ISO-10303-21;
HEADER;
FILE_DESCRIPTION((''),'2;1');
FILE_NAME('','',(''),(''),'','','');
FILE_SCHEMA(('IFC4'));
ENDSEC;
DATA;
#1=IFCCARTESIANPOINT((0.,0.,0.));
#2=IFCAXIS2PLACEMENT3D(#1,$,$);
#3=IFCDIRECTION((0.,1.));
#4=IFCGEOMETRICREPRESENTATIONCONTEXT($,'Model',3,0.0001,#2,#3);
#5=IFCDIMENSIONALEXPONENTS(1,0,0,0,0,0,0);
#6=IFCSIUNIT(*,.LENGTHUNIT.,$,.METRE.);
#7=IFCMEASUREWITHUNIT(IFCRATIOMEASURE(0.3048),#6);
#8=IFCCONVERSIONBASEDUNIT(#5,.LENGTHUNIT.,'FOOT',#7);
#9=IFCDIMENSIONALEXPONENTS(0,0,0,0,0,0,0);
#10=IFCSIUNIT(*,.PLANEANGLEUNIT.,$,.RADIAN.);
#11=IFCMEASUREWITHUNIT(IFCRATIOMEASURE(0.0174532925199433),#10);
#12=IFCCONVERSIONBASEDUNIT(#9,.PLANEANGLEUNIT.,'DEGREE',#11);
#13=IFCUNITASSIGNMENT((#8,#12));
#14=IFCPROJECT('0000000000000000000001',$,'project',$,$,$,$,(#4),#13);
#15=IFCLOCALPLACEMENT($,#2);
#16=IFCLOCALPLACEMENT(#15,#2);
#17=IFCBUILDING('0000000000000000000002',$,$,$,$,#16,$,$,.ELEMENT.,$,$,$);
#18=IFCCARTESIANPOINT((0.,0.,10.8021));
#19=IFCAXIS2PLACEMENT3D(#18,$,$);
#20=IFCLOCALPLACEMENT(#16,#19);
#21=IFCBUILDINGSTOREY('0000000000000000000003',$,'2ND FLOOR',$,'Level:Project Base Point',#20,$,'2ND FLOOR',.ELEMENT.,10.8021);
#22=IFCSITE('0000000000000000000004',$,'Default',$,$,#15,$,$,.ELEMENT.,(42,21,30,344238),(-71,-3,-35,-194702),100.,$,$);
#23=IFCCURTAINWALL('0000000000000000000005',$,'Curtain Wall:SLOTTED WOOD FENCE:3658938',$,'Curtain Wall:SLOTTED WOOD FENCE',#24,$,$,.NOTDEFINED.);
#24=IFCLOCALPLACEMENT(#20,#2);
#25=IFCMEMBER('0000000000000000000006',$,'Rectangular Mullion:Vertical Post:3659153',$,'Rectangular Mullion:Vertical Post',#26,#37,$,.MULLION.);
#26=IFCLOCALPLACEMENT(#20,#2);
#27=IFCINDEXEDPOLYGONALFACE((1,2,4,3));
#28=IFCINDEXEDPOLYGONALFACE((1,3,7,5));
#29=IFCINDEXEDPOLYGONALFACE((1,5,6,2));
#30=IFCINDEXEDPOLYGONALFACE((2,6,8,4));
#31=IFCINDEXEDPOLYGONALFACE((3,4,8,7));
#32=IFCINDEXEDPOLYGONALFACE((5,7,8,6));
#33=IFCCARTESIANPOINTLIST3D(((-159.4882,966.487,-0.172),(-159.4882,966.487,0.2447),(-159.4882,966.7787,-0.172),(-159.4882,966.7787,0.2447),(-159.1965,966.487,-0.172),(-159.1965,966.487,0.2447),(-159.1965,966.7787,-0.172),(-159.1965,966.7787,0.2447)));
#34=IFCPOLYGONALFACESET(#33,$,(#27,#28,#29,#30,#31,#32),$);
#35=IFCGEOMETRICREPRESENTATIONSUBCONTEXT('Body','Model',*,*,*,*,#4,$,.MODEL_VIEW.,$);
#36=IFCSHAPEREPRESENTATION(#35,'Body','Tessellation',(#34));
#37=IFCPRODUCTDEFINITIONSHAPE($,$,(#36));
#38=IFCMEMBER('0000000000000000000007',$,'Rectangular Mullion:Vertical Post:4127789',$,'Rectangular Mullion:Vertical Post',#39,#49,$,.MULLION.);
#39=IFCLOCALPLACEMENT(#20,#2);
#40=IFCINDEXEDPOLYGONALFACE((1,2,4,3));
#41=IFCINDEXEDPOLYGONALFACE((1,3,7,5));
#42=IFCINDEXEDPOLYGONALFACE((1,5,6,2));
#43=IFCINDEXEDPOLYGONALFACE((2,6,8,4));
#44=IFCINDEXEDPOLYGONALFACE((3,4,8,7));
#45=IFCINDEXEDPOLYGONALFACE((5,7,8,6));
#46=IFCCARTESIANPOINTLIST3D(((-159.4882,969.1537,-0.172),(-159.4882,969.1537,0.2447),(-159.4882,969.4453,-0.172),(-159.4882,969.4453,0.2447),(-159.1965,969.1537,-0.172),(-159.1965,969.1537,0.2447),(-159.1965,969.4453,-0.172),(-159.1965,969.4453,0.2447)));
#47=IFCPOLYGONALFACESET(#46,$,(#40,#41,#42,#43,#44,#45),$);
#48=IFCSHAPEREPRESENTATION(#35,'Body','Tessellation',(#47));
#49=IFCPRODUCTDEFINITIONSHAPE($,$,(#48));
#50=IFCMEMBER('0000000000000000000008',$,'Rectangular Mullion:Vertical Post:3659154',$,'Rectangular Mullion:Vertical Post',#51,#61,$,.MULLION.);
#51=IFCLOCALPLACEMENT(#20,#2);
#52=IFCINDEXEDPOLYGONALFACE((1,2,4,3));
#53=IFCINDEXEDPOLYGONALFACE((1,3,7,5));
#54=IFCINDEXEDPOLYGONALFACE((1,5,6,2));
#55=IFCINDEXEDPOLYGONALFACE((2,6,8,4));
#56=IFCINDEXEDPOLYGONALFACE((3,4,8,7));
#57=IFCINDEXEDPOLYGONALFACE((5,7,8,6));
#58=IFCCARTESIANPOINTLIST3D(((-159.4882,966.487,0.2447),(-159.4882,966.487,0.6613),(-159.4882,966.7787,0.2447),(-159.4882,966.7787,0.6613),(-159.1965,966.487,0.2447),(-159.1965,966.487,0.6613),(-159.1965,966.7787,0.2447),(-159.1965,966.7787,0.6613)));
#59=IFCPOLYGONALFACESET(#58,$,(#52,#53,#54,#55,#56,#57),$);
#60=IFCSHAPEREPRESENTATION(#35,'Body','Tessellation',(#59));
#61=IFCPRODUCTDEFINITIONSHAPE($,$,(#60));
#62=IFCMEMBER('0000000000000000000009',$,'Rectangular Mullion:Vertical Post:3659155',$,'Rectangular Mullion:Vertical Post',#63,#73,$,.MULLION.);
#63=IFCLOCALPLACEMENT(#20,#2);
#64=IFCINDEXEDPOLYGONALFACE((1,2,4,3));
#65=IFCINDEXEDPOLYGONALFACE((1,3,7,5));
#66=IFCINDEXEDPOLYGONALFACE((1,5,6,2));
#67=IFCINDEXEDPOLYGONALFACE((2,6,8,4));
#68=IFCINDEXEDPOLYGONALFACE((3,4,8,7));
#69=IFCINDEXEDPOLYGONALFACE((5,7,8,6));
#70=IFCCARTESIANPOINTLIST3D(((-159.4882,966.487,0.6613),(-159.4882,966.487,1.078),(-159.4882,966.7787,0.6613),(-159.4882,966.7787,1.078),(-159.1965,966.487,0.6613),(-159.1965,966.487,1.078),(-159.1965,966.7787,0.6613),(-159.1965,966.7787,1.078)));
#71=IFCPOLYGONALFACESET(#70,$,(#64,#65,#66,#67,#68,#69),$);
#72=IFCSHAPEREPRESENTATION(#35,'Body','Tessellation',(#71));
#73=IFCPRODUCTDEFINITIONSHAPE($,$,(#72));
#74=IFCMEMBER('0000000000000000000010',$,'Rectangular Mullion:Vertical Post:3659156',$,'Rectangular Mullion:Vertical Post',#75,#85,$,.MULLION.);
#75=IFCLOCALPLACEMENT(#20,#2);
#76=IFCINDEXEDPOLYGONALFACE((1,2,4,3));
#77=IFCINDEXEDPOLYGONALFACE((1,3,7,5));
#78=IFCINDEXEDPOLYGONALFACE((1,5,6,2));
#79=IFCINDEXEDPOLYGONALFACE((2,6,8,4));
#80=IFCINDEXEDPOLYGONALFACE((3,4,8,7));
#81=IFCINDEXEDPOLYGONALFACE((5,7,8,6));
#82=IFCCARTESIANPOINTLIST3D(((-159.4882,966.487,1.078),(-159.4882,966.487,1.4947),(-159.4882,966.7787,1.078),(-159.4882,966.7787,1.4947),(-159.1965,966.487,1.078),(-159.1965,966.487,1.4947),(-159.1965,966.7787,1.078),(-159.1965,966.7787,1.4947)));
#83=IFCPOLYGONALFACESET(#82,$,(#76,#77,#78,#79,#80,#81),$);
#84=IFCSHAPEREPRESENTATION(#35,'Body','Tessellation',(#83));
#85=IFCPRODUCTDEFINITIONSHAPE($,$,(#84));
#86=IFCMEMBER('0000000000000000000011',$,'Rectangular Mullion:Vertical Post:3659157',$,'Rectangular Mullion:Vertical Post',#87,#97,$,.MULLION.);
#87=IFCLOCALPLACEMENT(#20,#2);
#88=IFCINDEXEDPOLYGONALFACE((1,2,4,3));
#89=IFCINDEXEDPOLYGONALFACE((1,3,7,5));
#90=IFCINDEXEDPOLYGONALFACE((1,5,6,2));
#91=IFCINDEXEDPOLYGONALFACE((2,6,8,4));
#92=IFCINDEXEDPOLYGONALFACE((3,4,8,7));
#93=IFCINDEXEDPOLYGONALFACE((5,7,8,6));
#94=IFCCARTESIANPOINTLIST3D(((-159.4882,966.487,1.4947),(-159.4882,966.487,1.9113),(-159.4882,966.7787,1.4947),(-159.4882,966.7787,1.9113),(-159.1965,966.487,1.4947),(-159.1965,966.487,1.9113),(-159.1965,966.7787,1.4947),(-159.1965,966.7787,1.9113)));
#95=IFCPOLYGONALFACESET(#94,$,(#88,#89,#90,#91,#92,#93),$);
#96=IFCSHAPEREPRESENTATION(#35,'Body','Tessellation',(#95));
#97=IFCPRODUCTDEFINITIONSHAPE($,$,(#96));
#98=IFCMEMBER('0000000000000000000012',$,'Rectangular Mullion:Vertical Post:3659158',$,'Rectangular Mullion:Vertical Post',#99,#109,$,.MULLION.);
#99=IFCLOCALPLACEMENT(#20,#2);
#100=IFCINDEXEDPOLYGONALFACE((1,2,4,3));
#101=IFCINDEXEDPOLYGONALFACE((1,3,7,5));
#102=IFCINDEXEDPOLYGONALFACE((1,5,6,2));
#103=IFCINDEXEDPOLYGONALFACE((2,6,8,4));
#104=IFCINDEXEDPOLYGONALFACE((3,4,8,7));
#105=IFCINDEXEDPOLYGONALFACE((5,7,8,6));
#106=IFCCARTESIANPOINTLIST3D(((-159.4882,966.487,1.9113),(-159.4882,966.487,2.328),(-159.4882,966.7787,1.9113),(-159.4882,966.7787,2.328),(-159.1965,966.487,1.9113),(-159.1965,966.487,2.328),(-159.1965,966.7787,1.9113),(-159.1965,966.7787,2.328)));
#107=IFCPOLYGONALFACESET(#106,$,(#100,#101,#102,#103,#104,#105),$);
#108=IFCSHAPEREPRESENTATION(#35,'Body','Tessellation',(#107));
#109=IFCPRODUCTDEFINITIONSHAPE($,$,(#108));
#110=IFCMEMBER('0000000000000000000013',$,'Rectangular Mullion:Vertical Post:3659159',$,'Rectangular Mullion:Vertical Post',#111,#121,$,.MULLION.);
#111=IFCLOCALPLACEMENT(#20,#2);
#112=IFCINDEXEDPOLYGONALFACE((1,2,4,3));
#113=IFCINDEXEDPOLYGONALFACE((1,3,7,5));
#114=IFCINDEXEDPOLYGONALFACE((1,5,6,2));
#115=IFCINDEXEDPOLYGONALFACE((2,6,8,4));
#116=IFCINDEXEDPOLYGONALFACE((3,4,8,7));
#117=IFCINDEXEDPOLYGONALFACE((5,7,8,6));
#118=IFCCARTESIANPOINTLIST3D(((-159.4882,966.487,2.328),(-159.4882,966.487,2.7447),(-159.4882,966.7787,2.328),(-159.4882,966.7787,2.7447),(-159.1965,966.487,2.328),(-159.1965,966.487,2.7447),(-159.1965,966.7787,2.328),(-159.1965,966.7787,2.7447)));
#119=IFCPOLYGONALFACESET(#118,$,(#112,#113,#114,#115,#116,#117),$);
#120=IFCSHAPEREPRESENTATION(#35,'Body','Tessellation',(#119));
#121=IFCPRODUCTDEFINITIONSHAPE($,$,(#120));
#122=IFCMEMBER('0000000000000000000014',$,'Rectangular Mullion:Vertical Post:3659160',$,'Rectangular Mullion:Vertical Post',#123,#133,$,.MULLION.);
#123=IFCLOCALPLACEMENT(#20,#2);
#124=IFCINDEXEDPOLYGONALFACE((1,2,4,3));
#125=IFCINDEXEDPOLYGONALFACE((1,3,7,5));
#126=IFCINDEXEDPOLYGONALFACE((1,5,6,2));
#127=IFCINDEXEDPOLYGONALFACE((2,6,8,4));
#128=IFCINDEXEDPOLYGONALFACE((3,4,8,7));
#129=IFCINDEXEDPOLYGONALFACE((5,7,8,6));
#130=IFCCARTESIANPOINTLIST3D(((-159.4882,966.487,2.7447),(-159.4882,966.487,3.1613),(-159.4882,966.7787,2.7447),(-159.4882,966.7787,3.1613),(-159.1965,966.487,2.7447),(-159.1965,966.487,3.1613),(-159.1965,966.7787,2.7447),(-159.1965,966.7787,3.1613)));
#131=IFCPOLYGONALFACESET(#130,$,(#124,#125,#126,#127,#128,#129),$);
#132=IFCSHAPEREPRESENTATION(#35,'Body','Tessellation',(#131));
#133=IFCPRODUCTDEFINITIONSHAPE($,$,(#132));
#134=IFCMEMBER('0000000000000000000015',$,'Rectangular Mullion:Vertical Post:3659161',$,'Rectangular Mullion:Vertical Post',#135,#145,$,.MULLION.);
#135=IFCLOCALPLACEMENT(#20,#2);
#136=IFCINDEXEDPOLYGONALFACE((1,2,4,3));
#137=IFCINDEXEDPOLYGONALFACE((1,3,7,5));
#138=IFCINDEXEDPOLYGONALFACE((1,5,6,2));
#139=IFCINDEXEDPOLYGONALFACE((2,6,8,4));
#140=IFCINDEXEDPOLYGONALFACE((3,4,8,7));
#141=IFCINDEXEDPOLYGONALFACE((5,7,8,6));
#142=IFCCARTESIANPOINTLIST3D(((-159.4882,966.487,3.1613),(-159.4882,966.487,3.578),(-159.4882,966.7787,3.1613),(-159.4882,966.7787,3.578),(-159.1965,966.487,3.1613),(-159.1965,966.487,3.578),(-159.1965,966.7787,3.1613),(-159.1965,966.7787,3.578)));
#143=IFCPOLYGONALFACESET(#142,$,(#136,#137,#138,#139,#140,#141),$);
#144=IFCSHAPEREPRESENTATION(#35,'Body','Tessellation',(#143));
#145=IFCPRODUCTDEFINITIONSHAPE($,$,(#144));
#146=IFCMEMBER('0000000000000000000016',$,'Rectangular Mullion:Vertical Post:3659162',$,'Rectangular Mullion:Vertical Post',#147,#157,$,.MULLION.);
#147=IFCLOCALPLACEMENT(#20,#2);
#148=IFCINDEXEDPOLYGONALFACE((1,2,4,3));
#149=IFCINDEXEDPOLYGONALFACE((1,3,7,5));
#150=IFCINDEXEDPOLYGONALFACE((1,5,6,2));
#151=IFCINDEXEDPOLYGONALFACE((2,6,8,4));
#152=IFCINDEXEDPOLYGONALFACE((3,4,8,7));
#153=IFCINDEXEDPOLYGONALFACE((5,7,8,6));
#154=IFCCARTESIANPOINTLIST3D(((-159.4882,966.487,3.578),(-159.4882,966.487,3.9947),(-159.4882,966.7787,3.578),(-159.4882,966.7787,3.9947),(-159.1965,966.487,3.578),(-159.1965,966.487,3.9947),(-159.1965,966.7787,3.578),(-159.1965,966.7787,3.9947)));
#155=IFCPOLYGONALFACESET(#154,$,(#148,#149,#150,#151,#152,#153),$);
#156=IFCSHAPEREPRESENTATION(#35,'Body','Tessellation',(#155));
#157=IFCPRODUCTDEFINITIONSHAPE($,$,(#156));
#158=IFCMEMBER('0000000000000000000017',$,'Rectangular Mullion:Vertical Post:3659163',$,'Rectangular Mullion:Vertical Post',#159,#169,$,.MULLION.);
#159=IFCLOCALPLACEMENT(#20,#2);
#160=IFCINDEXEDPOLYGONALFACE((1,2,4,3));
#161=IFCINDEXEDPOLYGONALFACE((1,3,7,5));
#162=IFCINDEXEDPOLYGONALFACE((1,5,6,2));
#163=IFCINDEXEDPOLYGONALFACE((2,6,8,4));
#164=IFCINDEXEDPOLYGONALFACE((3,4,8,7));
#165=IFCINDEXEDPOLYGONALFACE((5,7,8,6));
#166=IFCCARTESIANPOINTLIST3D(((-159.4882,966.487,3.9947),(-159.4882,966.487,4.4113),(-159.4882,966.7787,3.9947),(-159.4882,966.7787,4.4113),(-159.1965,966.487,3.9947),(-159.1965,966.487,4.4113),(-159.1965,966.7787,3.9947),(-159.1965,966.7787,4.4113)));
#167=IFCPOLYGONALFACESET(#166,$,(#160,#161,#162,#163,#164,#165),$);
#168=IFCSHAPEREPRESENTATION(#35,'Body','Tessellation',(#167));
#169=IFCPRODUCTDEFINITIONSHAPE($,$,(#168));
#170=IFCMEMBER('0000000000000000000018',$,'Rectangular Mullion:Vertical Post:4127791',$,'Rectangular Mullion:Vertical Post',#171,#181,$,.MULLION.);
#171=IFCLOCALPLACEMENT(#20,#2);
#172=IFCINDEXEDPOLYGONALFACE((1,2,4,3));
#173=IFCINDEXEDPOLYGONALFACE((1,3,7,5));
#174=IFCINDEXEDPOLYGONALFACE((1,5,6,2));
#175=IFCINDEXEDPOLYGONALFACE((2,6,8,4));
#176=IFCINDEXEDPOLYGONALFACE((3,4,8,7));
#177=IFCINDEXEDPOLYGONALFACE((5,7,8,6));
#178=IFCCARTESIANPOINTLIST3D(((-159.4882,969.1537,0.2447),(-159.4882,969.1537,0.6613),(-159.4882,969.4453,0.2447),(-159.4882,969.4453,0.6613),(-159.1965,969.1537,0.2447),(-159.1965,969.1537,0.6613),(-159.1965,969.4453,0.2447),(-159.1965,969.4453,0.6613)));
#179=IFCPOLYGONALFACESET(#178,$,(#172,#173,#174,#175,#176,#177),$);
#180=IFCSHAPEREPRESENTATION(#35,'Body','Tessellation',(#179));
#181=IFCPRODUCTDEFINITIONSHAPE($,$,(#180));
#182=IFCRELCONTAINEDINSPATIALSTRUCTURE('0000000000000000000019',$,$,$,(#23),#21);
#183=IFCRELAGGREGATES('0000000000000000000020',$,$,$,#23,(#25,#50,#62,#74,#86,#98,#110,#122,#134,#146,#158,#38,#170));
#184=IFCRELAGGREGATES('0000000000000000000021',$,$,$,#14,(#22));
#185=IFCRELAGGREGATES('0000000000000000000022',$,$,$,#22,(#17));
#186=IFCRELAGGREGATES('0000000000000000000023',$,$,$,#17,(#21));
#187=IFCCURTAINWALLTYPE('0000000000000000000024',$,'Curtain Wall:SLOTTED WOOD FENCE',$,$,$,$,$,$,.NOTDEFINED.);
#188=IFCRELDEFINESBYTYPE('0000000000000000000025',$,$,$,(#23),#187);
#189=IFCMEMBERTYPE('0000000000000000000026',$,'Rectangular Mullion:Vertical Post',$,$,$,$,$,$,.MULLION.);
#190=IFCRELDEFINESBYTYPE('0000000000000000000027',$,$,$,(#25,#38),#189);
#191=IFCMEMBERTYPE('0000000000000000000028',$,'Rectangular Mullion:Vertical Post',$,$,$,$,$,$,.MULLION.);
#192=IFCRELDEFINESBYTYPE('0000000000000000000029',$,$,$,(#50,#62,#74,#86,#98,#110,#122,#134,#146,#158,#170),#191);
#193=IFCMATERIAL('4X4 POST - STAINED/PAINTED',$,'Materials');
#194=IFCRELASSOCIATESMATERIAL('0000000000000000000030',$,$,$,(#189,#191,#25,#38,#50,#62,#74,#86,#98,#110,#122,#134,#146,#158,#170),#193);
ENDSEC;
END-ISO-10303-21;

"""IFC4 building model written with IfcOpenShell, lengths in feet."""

from ifc_helpers import new_model, entity, si_unit, converted_unit, direction, frame, origin, origin_2d_with_axis, place, context, subcontext, project, spatial, rectangle, extrude, source, transform, mapped, material, material_profile, profile_set, profile_usage, type_object, type_shapes, element, aggregate, save


model = new_model("IFC4")

# Units and contexts
model_context = context("Model", 3, precision=0.0001, world=origin(), true_north=direction((0.0, 1.0)))
body_context = subcontext(model_context, "Body", "Model", "MODEL_VIEW")
ifc_project = project(units=[converted_unit("LENGTHUNIT", "FOOT", entity("IfcRatioMeasure", 0.3048), si_unit("LENGTHUNIT", "METRE"), dimensions=[1, 0, 0, 0, 0, 0, 0]), converted_unit("PLANEANGLEUNIT", "DEGREE", entity("IfcRatioMeasure", 0.0174532925199433), si_unit("PLANEANGLEUNIT", "RADIAN"), dimensions=[0, 0, 0, 0, 0, 0, 0])], contexts=[model_context])

# Site, building, storey
site_placement = place(None, origin())
site = spatial("IfcSite", under=ifc_project, at=site_placement, Name="Default", CompositionType="ELEMENT", RefLatitude=(42, 21, 30, 344238), RefLongitude=(-71, -3, -35, -194702), RefElevation=100.0)
building_placement = place(site_placement, origin())
building = spatial("IfcBuilding", under=site, at=building_placement, CompositionType="ELEMENT")
storey_placement = place(building_placement, frame((0.0, 0.0, 10.8021)))
storey = spatial("IfcBuildingStorey", under=building, at=storey_placement, Name="2ND FLOOR", ObjectType="Level:Project Base Point", LongName="2ND FLOOR", CompositionType="ELEMENT", Elevation=10.8021)

# Curtain wall, members
curtain_wall_type = type_object("IfcCurtainWallType", Name="Curtain Wall:SLOTTED WOOD FENCE", PredefinedType="NOTDEFINED")
curtain_wall_placement = place(storey_placement, frame((0.0, 0.0, -10.8021)))
curtain_wall = element("IfcCurtainWall", 1, at=curtain_wall_placement, inside=storey, type_object=curtain_wall_type, Name="Curtain Wall:SLOTTED WOOD FENCE:3658938", ObjectType="Curtain Wall:SLOTTED WOOD FENCE", PredefinedType="NOTDEFINED")
ifc_material_1 = material(Name="4X4 POST - STAINED/PAINTED", Category="Materials")
ifc_material_profile = material_profile(ifc_material_1, rectangle(XDim=0.2917, YDim=0.2917, at=origin_2d_with_axis()), Name="Vertical Post")
ifc_profile_set = profile_set([ifc_material_profile], Name="Vertical Post")
ifc_profile_usage_1 = profile_usage(ifc_profile_set)
member_type_1 = type_object("IfcMemberType", Name="Rectangular Mullion:Vertical Post", PredefinedType="MULLION", material=ifc_profile_set)
shared_shape_1 = source(origin(), body_context, "Body", "SweptSolid", [
    extrude(rectangle(XDim=0.2917, YDim=0.2917, at=origin_2d_with_axis()), frame((0.0, -0.2083, -0.4167), z_axis=(0.0, 0.0, 1.0), x_axis=(0.0, -1.0, 0.0)), (0.0, 0.0, 1.0), 0.4167),
])
type_shapes(member_type_1, [shared_shape_1])
member_1_placement = place(storey_placement, frame((-159.5507, 966.6328, -0.172), z_axis=(0.0, 0.0, -1.0), x_axis=(0.0, -1.0, 0.0)))
member_1 = element("IfcMember", 2, at=member_1_placement, type_object=member_type_1, material=ifc_profile_usage_1, Name="Rectangular Mullion:Vertical Post:3659153", ObjectType="Rectangular Mullion:Vertical Post", PredefinedType="MULLION", context=body_context, shape_type="MappedRepresentation", body=[
    mapped(shared_shape_1, transform((0.0, 0.0, 0.0), scale=1.0)),
])
ifc_profile_usage_2 = profile_usage(ifc_profile_set)
member_2_placement = place(storey_placement, frame((-159.5507, 969.2995, -0.172), z_axis=(0.0, 0.0, -1.0), x_axis=(0.0, -1.0, 0.0)))
member_2 = element("IfcMember", 3, at=member_2_placement, type_object=member_type_1, material=ifc_profile_usage_2, Name="Rectangular Mullion:Vertical Post:4127789", ObjectType="Rectangular Mullion:Vertical Post", PredefinedType="MULLION", context=body_context, shape_type="MappedRepresentation", body=[
    mapped(shared_shape_1, transform((0.0, 0.0, 0.0), scale=1.0)),
])
ifc_profile_usage_3 = profile_usage(ifc_profile_set)
member_type_2 = type_object("IfcMemberType", Name="Rectangular Mullion:Vertical Post", PredefinedType="MULLION", material=ifc_profile_set)
shared_shape_2 = source(origin(), body_context, "Body", "SweptSolid", [
    extrude(rectangle(XDim=0.2917, YDim=0.2917, at=origin_2d_with_axis()), frame((0.0, -0.2083, -0.4167), z_axis=(0.0, 0.0, 1.0), x_axis=(0.0, -1.0, 0.0)), (0.0, 0.0, 1.0), 0.4167),
])
type_shapes(member_type_2, [shared_shape_2])
member_3_placement = place(storey_placement, frame((-159.5507, 966.6328, 0.2447), z_axis=(0.0, 0.0, -1.0), x_axis=(0.0, -1.0, 0.0)))
member_3 = element("IfcMember", 4, at=member_3_placement, type_object=member_type_2, material=ifc_profile_usage_3, Name="Rectangular Mullion:Vertical Post:3659154", ObjectType="Rectangular Mullion:Vertical Post", PredefinedType="MULLION", context=body_context, shape_type="MappedRepresentation", body=[
    mapped(shared_shape_2, transform((0.0, 0.0, 0.0), scale=1.0)),
])
ifc_profile_usage_4 = profile_usage(ifc_profile_set)
member_4_placement = place(storey_placement, frame((-159.5507, 966.6328, 0.6613), z_axis=(0.0, 0.0, -1.0), x_axis=(0.0, -1.0, 0.0)))
member_4 = element("IfcMember", 5, at=member_4_placement, type_object=member_type_2, material=ifc_profile_usage_4, Name="Rectangular Mullion:Vertical Post:3659155", ObjectType="Rectangular Mullion:Vertical Post", PredefinedType="MULLION", context=body_context, shape_type="MappedRepresentation", body=[
    mapped(shared_shape_2, transform((0.0, 0.0, 0.0), scale=1.0)),
])
ifc_profile_usage_5 = profile_usage(ifc_profile_set)
member_5_placement = place(storey_placement, frame((-159.5507, 966.6328, 1.078), z_axis=(0.0, 0.0, -1.0), x_axis=(0.0, -1.0, 0.0)))
member_5 = element("IfcMember", 6, at=member_5_placement, type_object=member_type_2, material=ifc_profile_usage_5, Name="Rectangular Mullion:Vertical Post:3659156", ObjectType="Rectangular Mullion:Vertical Post", PredefinedType="MULLION", context=body_context, shape_type="MappedRepresentation", body=[
    mapped(shared_shape_2, transform((0.0, 0.0, 0.0), scale=1.0)),
])
ifc_profile_usage_6 = profile_usage(ifc_profile_set)
member_6_placement = place(storey_placement, frame((-159.5507, 966.6328, 1.4947), z_axis=(0.0, 0.0, -1.0), x_axis=(0.0, -1.0, 0.0)))
member_6 = element("IfcMember", 7, at=member_6_placement, type_object=member_type_2, material=ifc_profile_usage_6, Name="Rectangular Mullion:Vertical Post:3659157", ObjectType="Rectangular Mullion:Vertical Post", PredefinedType="MULLION", context=body_context, shape_type="MappedRepresentation", body=[
    mapped(shared_shape_2, transform((0.0, 0.0, 0.0), scale=1.0)),
])
ifc_profile_usage_7 = profile_usage(ifc_profile_set)
member_7_placement = place(storey_placement, frame((-159.5507, 966.6328, 1.9113), z_axis=(0.0, 0.0, -1.0), x_axis=(0.0, -1.0, 0.0)))
member_7 = element("IfcMember", 8, at=member_7_placement, type_object=member_type_2, material=ifc_profile_usage_7, Name="Rectangular Mullion:Vertical Post:3659158", ObjectType="Rectangular Mullion:Vertical Post", PredefinedType="MULLION", context=body_context, shape_type="MappedRepresentation", body=[
    mapped(shared_shape_2, transform((0.0, 0.0, 0.0), scale=1.0)),
])
ifc_profile_usage_8 = profile_usage(ifc_profile_set)
member_8_placement = place(storey_placement, frame((-159.5507, 966.6328, 2.328), z_axis=(0.0, 0.0, -1.0), x_axis=(0.0, -1.0, 0.0)))
member_8 = element("IfcMember", 9, at=member_8_placement, type_object=member_type_2, material=ifc_profile_usage_8, Name="Rectangular Mullion:Vertical Post:3659159", ObjectType="Rectangular Mullion:Vertical Post", PredefinedType="MULLION", context=body_context, shape_type="MappedRepresentation", body=[
    mapped(shared_shape_2, transform((0.0, 0.0, 0.0), scale=1.0)),
])
ifc_profile_usage_9 = profile_usage(ifc_profile_set)
member_9_placement = place(storey_placement, frame((-159.5507, 966.6328, 2.7447), z_axis=(0.0, 0.0, -1.0), x_axis=(0.0, -1.0, 0.0)))
member_9 = element("IfcMember", 10, at=member_9_placement, type_object=member_type_2, material=ifc_profile_usage_9, Name="Rectangular Mullion:Vertical Post:3659160", ObjectType="Rectangular Mullion:Vertical Post", PredefinedType="MULLION", context=body_context, shape_type="MappedRepresentation", body=[
    mapped(shared_shape_2, transform((0.0, 0.0, 0.0), scale=1.0)),
])
ifc_profile_usage_10 = profile_usage(ifc_profile_set)
member_10_placement = place(storey_placement, frame((-159.5507, 966.6328, 3.1613), z_axis=(0.0, 0.0, -1.0), x_axis=(0.0, -1.0, 0.0)))
member_10 = element("IfcMember", 11, at=member_10_placement, type_object=member_type_2, material=ifc_profile_usage_10, Name="Rectangular Mullion:Vertical Post:3659161", ObjectType="Rectangular Mullion:Vertical Post", PredefinedType="MULLION", context=body_context, shape_type="MappedRepresentation", body=[
    mapped(shared_shape_2, transform((0.0, 0.0, 0.0), scale=1.0)),
])
ifc_profile_usage_11 = profile_usage(ifc_profile_set)
member_11_placement = place(storey_placement, frame((-159.5507, 966.6328, 3.578), z_axis=(0.0, 0.0, -1.0), x_axis=(0.0, -1.0, 0.0)))
member_11 = element("IfcMember", 12, at=member_11_placement, type_object=member_type_2, material=ifc_profile_usage_11, Name="Rectangular Mullion:Vertical Post:3659162", ObjectType="Rectangular Mullion:Vertical Post", PredefinedType="MULLION", context=body_context, shape_type="MappedRepresentation", body=[
    mapped(shared_shape_2, transform((0.0, 0.0, 0.0), scale=1.0)),
])
ifc_profile_usage_12 = profile_usage(ifc_profile_set)
member_12_placement = place(storey_placement, frame((-159.5507, 966.6328, 3.9947), z_axis=(0.0, 0.0, -1.0), x_axis=(0.0, -1.0, 0.0)))
member_12 = element("IfcMember", 13, at=member_12_placement, type_object=member_type_2, material=ifc_profile_usage_12, Name="Rectangular Mullion:Vertical Post:3659163", ObjectType="Rectangular Mullion:Vertical Post", PredefinedType="MULLION", context=body_context, shape_type="MappedRepresentation", body=[
    mapped(shared_shape_2, transform((0.0, 0.0, 0.0), scale=1.0)),
])
ifc_profile_usage_13 = profile_usage(ifc_profile_set)
member_13_placement = place(storey_placement, frame((-159.5507, 969.2995, 0.2447), z_axis=(0.0, 0.0, -1.0), x_axis=(0.0, -1.0, 0.0)))
member_13 = element("IfcMember", 14, at=member_13_placement, type_object=member_type_2, material=ifc_profile_usage_13, Name="Rectangular Mullion:Vertical Post:4127791", ObjectType="Rectangular Mullion:Vertical Post", PredefinedType="MULLION", context=body_context, shape_type="MappedRepresentation", body=[
    mapped(shared_shape_2, transform((0.0, 0.0, 0.0), scale=1.0)),
])
aggregate(curtain_wall, [member_1, member_3, member_4, member_5, member_6, member_7, member_8, member_9, member_10, member_11, member_12, member_2, member_13])

save(model, "model.ifc")
